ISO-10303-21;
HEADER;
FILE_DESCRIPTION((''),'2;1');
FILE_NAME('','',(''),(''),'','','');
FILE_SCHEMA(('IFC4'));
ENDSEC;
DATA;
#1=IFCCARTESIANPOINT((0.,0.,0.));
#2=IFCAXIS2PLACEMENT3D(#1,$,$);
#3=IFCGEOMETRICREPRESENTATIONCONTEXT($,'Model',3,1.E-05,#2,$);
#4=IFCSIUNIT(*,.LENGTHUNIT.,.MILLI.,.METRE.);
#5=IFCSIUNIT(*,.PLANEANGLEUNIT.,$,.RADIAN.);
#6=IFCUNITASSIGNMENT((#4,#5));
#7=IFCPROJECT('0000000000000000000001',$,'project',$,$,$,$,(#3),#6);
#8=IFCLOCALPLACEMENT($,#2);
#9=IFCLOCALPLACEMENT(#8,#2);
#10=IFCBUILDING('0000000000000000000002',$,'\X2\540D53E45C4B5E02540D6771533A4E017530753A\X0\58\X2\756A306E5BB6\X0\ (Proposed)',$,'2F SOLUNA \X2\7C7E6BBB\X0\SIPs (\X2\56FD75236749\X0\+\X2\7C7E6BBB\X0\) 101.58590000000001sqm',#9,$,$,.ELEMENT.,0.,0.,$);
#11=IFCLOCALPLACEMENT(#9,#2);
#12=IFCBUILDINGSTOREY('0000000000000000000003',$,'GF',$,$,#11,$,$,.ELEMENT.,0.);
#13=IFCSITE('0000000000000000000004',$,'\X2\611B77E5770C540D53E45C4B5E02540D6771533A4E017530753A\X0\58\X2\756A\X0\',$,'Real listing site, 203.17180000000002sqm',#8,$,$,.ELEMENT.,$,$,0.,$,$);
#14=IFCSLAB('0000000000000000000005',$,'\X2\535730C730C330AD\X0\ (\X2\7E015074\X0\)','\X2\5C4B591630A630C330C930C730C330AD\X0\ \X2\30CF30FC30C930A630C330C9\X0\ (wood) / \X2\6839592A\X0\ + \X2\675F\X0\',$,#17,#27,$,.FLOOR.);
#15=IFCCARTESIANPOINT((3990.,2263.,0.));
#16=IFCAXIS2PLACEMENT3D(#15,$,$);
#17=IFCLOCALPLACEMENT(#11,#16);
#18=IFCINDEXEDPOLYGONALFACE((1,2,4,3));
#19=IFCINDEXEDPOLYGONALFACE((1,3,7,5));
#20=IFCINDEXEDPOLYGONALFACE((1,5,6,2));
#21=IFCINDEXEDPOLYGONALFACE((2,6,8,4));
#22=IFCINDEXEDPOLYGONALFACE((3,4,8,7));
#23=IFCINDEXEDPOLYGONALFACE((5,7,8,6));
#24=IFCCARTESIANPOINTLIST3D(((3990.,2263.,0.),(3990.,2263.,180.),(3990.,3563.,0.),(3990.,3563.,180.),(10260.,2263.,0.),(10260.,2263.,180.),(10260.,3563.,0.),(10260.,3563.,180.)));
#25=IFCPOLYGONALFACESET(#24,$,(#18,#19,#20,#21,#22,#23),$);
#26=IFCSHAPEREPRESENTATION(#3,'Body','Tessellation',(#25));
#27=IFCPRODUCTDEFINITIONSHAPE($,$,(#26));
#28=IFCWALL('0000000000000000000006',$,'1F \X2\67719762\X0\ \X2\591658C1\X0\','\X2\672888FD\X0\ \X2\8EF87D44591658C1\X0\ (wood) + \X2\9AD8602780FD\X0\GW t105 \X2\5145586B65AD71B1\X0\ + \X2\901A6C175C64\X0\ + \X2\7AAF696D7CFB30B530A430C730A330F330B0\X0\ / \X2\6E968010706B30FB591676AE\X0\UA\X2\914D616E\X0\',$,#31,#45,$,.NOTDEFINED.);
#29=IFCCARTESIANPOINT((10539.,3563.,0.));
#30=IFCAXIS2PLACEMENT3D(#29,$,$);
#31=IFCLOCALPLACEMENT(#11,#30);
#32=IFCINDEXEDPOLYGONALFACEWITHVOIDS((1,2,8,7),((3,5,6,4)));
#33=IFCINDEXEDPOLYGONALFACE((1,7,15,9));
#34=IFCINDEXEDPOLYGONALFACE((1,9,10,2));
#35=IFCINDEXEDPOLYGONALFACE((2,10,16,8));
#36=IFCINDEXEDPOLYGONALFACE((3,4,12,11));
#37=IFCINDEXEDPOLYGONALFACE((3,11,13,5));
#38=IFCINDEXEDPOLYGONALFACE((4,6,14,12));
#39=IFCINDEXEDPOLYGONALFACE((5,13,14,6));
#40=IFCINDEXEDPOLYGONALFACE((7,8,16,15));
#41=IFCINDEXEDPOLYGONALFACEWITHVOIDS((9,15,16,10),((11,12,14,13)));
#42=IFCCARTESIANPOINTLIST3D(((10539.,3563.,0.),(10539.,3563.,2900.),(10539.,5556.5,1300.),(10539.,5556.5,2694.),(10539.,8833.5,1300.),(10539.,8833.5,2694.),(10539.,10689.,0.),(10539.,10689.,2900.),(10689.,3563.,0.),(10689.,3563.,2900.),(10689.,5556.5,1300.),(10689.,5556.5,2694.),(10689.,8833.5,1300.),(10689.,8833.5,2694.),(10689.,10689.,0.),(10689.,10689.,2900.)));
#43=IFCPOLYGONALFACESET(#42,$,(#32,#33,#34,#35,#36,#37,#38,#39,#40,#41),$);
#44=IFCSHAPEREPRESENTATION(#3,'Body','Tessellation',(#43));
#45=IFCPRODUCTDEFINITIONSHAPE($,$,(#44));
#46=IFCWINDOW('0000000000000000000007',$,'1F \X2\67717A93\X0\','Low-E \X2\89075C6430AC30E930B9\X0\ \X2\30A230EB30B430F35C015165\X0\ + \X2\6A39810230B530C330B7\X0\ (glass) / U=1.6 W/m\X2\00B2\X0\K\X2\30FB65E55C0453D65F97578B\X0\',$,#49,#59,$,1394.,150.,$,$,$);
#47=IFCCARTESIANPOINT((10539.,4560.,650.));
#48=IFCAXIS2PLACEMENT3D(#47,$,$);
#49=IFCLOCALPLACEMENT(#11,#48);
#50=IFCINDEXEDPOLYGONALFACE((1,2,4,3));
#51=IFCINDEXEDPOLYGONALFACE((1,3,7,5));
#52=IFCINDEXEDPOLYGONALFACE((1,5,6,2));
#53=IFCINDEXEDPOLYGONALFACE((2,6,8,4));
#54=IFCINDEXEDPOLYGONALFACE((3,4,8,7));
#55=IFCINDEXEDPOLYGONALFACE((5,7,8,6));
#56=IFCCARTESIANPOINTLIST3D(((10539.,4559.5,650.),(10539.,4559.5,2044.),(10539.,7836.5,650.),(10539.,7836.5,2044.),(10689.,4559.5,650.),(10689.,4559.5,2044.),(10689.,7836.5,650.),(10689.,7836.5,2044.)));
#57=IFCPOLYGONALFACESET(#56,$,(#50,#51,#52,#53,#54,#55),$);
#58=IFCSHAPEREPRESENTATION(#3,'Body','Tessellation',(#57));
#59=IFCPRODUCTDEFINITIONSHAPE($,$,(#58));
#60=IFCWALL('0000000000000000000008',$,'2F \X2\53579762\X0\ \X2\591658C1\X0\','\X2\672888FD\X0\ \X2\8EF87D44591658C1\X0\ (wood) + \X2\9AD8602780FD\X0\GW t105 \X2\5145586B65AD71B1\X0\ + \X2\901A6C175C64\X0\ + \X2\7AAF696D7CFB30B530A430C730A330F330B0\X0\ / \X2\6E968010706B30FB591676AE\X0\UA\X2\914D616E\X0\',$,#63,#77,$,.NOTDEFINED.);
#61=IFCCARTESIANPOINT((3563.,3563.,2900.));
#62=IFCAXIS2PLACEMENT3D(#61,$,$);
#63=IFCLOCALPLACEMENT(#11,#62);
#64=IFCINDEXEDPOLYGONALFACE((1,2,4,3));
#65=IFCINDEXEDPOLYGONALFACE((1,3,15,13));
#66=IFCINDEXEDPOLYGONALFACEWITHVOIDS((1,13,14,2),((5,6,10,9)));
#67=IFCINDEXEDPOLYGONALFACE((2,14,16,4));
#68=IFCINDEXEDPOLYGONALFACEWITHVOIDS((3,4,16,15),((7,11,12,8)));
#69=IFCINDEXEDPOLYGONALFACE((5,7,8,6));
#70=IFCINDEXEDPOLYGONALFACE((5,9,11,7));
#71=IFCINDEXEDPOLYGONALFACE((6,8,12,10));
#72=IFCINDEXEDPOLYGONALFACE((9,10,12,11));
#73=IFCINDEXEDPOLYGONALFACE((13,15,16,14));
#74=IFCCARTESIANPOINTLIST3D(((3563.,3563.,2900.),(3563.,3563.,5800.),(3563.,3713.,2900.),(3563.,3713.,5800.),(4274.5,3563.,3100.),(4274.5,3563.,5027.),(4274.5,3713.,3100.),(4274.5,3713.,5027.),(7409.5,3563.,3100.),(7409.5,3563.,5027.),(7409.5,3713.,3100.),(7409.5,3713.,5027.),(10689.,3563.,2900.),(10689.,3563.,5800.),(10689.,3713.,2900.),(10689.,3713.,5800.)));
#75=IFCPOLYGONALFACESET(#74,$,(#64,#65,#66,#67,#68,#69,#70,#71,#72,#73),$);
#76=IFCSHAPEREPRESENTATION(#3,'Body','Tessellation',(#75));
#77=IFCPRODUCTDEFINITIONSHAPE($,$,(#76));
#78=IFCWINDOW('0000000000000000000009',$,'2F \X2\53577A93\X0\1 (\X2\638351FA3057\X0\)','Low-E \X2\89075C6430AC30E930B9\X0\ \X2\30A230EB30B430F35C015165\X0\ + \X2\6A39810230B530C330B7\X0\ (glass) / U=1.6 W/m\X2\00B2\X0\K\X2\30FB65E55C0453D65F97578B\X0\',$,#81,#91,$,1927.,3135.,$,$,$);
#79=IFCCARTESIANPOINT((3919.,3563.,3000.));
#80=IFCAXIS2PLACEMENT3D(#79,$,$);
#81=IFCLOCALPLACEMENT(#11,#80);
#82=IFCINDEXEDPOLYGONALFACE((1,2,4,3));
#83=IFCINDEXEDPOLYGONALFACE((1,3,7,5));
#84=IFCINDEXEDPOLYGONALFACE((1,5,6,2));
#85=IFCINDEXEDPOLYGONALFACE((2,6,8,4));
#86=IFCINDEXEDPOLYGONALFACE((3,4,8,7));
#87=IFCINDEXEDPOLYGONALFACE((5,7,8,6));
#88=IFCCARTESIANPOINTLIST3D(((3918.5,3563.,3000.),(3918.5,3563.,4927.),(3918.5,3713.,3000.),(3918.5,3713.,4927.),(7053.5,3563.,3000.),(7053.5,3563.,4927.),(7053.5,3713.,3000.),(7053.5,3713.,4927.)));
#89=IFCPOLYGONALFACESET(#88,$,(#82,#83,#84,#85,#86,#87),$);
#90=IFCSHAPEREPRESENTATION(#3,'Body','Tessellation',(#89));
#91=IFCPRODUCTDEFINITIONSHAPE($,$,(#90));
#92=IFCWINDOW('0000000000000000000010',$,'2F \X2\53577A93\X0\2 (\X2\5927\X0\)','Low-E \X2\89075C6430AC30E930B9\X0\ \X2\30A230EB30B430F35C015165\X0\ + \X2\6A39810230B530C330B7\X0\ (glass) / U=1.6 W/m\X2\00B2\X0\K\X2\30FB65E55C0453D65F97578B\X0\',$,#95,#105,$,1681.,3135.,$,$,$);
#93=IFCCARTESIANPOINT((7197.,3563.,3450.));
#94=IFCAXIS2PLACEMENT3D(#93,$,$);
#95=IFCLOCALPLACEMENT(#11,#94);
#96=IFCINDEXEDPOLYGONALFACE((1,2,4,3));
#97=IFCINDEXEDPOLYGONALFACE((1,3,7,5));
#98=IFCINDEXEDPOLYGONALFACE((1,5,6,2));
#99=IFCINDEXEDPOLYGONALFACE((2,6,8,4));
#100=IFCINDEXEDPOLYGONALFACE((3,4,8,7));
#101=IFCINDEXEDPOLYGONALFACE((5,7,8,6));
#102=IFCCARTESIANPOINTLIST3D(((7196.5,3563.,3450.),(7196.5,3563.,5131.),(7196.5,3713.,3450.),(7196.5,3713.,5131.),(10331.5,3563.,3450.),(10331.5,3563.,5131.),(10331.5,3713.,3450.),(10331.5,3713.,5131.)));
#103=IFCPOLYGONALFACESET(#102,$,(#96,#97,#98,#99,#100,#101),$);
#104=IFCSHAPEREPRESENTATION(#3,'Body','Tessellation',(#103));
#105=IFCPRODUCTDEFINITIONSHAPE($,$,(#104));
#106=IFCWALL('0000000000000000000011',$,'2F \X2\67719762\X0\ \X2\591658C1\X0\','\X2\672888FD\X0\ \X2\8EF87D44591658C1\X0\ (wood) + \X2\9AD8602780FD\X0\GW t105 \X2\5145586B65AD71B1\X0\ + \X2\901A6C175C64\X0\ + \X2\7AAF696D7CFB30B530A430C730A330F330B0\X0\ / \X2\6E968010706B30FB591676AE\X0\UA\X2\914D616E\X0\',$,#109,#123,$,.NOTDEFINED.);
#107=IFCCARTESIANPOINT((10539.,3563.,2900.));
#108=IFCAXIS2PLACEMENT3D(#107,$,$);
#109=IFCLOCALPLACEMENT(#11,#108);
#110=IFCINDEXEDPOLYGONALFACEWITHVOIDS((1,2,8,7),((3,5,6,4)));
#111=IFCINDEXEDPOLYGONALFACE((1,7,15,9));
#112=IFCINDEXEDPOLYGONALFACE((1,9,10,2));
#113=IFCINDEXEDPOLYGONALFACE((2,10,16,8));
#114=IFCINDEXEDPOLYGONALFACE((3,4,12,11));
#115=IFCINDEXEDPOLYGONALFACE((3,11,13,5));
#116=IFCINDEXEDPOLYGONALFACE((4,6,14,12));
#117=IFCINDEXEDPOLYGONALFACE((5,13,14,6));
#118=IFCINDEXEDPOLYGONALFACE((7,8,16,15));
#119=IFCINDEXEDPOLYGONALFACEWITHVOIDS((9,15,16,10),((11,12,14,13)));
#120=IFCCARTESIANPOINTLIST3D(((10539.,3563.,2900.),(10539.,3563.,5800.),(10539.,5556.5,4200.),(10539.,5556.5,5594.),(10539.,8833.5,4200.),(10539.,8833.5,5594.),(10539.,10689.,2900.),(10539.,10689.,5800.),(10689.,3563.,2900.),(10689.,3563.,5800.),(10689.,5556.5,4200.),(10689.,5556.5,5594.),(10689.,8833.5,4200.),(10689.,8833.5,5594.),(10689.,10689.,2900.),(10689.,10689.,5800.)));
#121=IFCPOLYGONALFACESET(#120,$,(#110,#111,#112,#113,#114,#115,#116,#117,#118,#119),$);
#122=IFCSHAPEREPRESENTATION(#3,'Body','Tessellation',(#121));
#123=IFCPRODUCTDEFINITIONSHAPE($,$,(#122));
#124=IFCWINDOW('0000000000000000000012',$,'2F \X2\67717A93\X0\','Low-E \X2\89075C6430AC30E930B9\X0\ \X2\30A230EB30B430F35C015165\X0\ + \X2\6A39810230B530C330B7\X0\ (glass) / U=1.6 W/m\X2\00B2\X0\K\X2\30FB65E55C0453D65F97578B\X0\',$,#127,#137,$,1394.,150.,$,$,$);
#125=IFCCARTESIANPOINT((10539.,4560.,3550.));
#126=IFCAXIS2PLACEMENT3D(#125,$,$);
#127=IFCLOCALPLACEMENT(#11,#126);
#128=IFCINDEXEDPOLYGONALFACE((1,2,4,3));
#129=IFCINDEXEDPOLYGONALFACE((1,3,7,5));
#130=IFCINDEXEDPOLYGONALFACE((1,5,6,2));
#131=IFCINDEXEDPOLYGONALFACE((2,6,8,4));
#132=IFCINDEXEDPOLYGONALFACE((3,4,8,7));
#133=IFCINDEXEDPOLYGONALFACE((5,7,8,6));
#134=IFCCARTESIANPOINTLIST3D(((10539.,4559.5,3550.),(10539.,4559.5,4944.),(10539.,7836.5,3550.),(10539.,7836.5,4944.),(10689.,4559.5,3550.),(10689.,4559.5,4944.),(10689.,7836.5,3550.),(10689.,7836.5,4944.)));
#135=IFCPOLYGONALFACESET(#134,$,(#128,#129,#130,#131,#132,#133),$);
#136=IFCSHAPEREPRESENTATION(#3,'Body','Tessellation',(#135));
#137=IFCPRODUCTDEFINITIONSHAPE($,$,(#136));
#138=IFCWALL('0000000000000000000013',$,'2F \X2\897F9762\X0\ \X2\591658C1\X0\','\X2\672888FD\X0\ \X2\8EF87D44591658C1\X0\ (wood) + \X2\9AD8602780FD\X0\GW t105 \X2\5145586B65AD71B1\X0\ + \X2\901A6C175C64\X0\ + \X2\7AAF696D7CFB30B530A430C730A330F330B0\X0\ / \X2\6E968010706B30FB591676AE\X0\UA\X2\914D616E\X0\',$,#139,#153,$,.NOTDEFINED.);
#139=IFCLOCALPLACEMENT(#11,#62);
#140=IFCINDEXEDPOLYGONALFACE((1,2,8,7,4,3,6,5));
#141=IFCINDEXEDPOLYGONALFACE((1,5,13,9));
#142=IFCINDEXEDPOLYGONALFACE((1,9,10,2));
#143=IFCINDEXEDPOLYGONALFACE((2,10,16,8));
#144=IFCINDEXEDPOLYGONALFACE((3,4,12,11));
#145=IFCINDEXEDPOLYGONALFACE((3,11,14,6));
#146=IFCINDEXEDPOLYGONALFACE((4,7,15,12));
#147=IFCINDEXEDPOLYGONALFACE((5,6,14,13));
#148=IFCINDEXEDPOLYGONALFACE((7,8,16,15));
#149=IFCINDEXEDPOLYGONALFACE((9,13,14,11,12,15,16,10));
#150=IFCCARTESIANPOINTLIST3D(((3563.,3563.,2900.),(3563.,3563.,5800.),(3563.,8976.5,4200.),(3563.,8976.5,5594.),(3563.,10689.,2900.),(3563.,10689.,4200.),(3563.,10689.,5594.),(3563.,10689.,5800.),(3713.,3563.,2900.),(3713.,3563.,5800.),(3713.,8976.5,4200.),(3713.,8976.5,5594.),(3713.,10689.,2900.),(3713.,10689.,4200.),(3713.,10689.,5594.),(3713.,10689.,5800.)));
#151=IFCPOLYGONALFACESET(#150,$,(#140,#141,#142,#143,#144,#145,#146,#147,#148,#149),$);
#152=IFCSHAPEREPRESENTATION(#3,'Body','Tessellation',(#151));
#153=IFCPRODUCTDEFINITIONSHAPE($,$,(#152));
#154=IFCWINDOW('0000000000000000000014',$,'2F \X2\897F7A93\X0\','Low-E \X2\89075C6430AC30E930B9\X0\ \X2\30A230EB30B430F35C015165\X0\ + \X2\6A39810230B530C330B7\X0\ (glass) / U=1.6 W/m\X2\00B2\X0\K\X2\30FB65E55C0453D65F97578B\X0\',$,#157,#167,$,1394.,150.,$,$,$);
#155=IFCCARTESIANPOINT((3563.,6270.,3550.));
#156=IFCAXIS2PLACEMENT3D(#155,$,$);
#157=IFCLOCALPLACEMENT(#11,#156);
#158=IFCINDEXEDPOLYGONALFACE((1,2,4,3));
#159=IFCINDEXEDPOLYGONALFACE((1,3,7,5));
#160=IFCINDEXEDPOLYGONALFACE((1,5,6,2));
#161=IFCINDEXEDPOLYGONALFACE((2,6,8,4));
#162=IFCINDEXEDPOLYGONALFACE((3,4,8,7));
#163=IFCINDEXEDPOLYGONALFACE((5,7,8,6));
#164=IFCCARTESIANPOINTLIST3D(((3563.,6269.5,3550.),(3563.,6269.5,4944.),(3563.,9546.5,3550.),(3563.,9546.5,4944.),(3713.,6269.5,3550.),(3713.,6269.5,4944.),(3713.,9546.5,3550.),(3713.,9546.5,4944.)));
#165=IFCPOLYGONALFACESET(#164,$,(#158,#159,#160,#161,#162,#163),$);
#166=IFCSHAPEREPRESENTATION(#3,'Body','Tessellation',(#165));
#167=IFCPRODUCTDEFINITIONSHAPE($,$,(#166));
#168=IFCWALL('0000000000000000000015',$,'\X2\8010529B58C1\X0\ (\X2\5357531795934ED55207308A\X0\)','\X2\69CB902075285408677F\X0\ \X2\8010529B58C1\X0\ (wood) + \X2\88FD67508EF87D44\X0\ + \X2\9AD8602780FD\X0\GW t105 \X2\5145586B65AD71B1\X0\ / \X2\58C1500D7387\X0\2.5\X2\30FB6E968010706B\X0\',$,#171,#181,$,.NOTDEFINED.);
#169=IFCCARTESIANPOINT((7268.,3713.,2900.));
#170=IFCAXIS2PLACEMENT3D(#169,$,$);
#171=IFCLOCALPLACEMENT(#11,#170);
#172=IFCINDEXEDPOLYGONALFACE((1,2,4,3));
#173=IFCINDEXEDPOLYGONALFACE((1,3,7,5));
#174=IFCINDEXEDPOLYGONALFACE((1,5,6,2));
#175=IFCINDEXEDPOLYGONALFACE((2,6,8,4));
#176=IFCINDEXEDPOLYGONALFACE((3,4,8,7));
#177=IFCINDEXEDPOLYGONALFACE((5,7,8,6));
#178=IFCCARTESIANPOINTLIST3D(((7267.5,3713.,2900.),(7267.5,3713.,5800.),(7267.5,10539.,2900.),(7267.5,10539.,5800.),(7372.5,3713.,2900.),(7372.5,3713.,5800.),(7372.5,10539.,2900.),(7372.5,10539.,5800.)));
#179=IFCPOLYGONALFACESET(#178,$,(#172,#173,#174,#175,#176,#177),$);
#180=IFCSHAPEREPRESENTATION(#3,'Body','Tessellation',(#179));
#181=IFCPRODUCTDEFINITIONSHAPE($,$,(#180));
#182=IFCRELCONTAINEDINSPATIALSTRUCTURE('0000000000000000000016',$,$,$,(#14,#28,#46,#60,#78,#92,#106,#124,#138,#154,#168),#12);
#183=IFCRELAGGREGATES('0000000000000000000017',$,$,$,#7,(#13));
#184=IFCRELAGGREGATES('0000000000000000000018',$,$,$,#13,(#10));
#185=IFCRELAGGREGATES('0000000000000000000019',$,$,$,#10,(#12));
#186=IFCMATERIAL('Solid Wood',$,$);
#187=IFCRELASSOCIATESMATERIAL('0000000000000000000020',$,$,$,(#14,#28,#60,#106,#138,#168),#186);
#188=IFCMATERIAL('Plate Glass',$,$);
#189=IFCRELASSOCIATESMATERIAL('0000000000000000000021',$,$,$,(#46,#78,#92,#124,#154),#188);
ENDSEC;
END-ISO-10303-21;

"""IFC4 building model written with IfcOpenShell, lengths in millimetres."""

from ifc_helpers import new_model, si_unit, frame, frame_2d, origin, place, context, project, spatial, rectangle, extrude, material, element, fill, save


model = new_model("IFC4")

# Units and contexts
model_context = context("Model", 3, precision=1e-05, world=origin())
ifc_project = project(units=[si_unit("LENGTHUNIT", "METRE", prefix="MILLI"), si_unit("PLANEANGLEUNIT", "RADIAN")], contexts=[model_context])

# Site, building, storey
site_placement = place(None, origin())
site = spatial("IfcSite", under=ifc_project, at=site_placement, Name="愛知県名古屋市名東区丁田町58番", ObjectType="Real listing site, 203.17180000000002sqm", CompositionType="ELEMENT", RefElevation=0.0)
building_placement = place(site_placement, origin())
building = spatial("IfcBuilding", under=site, at=building_placement, Name="名古屋市名東区丁田町58番の家 (Proposed)", ObjectType="2F SOLUNA 籾殻SIPs (国産杉+籾殻) 101.58590000000001sqm", CompositionType="ELEMENT", ElevationOfRefHeight=0.0, ElevationOfTerrain=0.0)
storey_placement = place(building_placement, origin())
storey = spatial("IfcBuildingStorey", under=building, at=storey_placement, Name="GF", CompositionType="ELEMENT", Elevation=0.0)

# Slab
ifc_material_1 = material(Name="Solid Wood")
slab_1_placement = place(storey_placement, frame((3990.0, 2263.0, 0.0)))
element("IfcSlab", 1, at=slab_1_placement, inside=storey, material=ifc_material_1, Name="南デッキ (縁側)", Description="屋外ウッドデッキ ハードウッド (wood) / 根太 + 束", PredefinedType="FLOOR", context=model_context, shape_type="SweptSolid", body=[
    extrude(rectangle(XDim=6270.0, YDim=1300.0, at=frame_2d((3135.0, 650.0))), frame((3990.0, 2263.0, 0.0)), (0.0, 0.0, 1.0), 180.0),
])

# Shared definitions
ifc_material_2 = material(Name="Plate Glass")

# Wall, opening, window
wall_1_placement = place(storey_placement, frame((10539.0, 3563.0, 0.0)))
wall_1 = element("IfcWall", 2, at=wall_1_placement, inside=storey, material=ifc_material_1, Name="1F 東面 外壁", Description="木製 軸組外壁 (wood) + 高性能GW t105 充填断熱 + 通気層 + 窯業系サイディング / 準耐火・外皮UA配慮", PredefinedType="NOTDEFINED", context=model_context, shape_type="SweptSolid", body=[
    extrude(rectangle(XDim=150.0, YDim=7126.0, at=frame_2d((75.0, 3563.0))), frame((10539.0, 3563.0, 0.0)), (0.0, 0.0, 1.0), 2900.0),
])
opening_1_placement = place(storey_placement, frame((10539.0, 4560.0, 650.0)))
opening_1 = element("IfcOpeningElement", 3, at=opening_1_placement, cuts=wall_1, PredefinedType="NOTDEFINED", context=model_context, shape_type="SweptSolid", body=[
    extrude(rectangle(XDim=150.0, YDim=3277.0, at=frame_2d((75.0, 1638.0))), frame((10539.0, 4560.0, 650.0)), (0.0, 0.0, 1.0), 1394.0),
])
window_1_placement = place(storey_placement, frame((10539.0, 4560.0, 650.0)))
window_1 = element("IfcWindow", 4, at=window_1_placement, inside=storey, material=ifc_material_2, Name="1F 東窓", Description="Low-E 複層ガラス アルゴン封入 + 樹脂サッシ (glass) / U=1.6 W/m²K・日射取得型", OverallHeight=1394.0, OverallWidth=150.0, context=model_context, shape_type="SweptSolid", body=[
    extrude(rectangle(XDim=150.0, YDim=3277.0, at=frame_2d((75.0, 1638.0))), frame((10539.0, 4560.0, 650.0)), (0.0, 0.0, 1.0), 1394.0),
])
fill(opening_1, window_1)

# Wall, openings, windows
wall_2_placement = place(storey_placement, frame((3563.0, 3563.0, 2900.0)))
wall_2 = element("IfcWall", 5, at=wall_2_placement, inside=storey, material=ifc_material_1, Name="2F 南面 外壁", Description="木製 軸組外壁 (wood) + 高性能GW t105 充填断熱 + 通気層 + 窯業系サイディング / 準耐火・外皮UA配慮", PredefinedType="NOTDEFINED", context=model_context, shape_type="SweptSolid", body=[
    extrude(rectangle(XDim=7126.0, YDim=150.0, at=frame_2d((3563.0, 75.0))), frame((3563.0, 3563.0, 2900.0)), (0.0, 0.0, 1.0), 2900.0),
])
opening_2_placement = place(storey_placement, frame((3919.0, 3563.0, 3000.0)))
opening_2 = element("IfcOpeningElement", 6, at=opening_2_placement, cuts=wall_2, PredefinedType="NOTDEFINED", context=model_context, shape_type="SweptSolid", body=[
    extrude(rectangle(XDim=3135.0, YDim=150.0, at=frame_2d((1567.0, 75.0))), frame((3919.0, 3563.0, 3000.0)), (0.0, 0.0, 1.0), 1927.0),
])
opening_3_placement = place(storey_placement, frame((7197.0, 3563.0, 3450.0)))
opening_3 = element("IfcOpeningElement", 7, at=opening_3_placement, cuts=wall_2, PredefinedType="NOTDEFINED", context=model_context, shape_type="SweptSolid", body=[
    extrude(rectangle(XDim=3135.0, YDim=150.0, at=frame_2d((1567.0, 75.0))), frame((7197.0, 3563.0, 3450.0)), (0.0, 0.0, 1.0), 1681.0),
])
window_2_placement = place(storey_placement, frame((3919.0, 3563.0, 3000.0)))
window_2 = element("IfcWindow", 8, at=window_2_placement, inside=storey, material=ifc_material_2, Name="2F 南窓1 (掃出し)", Description="Low-E 複層ガラス アルゴン封入 + 樹脂サッシ (glass) / U=1.6 W/m²K・日射取得型", OverallHeight=1927.0, OverallWidth=3135.0, context=model_context, shape_type="SweptSolid", body=[
    extrude(rectangle(XDim=3135.0, YDim=150.0, at=frame_2d((1567.0, 75.0))), frame((3919.0, 3563.0, 3000.0)), (0.0, 0.0, 1.0), 1927.0),
])
fill(opening_2, window_2)
window_3_placement = place(storey_placement, frame((7197.0, 3563.0, 3450.0)))
window_3 = element("IfcWindow", 9, at=window_3_placement, inside=storey, material=ifc_material_2, Name="2F 南窓2 (大)", Description="Low-E 複層ガラス アルゴン封入 + 樹脂サッシ (glass) / U=1.6 W/m²K・日射取得型", OverallHeight=1681.0, OverallWidth=3135.0, context=model_context, shape_type="SweptSolid", body=[
    extrude(rectangle(XDim=3135.0, YDim=150.0, at=frame_2d((1567.0, 75.0))), frame((7197.0, 3563.0, 3450.0)), (0.0, 0.0, 1.0), 1681.0),
])
fill(opening_3, window_3)

# Walls, openings, windows
wall_3_placement = place(storey_placement, frame((10539.0, 3563.0, 2900.0)))
wall_3 = element("IfcWall", 10, at=wall_3_placement, inside=storey, material=ifc_material_1, Name="2F 東面 外壁", Description="木製 軸組外壁 (wood) + 高性能GW t105 充填断熱 + 通気層 + 窯業系サイディング / 準耐火・外皮UA配慮", PredefinedType="NOTDEFINED", context=model_context, shape_type="SweptSolid", body=[
    extrude(rectangle(XDim=150.0, YDim=7126.0, at=frame_2d((75.0, 3563.0))), frame((10539.0, 3563.0, 2900.0)), (0.0, 0.0, 1.0), 2900.0),
])
opening_4_placement = place(storey_placement, frame((10539.0, 4560.0, 3550.0)))
opening_4 = element("IfcOpeningElement", 11, at=opening_4_placement, cuts=wall_3, PredefinedType="NOTDEFINED", context=model_context, shape_type="SweptSolid", body=[
    extrude(rectangle(XDim=150.0, YDim=3277.0, at=frame_2d((75.0, 1638.0))), frame((10539.0, 4560.0, 3550.0)), (0.0, 0.0, 1.0), 1394.0),
])
window_4_placement = place(storey_placement, frame((10539.0, 4560.0, 3550.0)))
window_4 = element("IfcWindow", 12, at=window_4_placement, inside=storey, material=ifc_material_2, Name="2F 東窓", Description="Low-E 複層ガラス アルゴン封入 + 樹脂サッシ (glass) / U=1.6 W/m²K・日射取得型", OverallHeight=1394.0, OverallWidth=150.0, context=model_context, shape_type="SweptSolid", body=[
    extrude(rectangle(XDim=150.0, YDim=3277.0, at=frame_2d((75.0, 1638.0))), frame((10539.0, 4560.0, 3550.0)), (0.0, 0.0, 1.0), 1394.0),
])
fill(opening_4, window_4)
wall_4_placement = place(storey_placement, frame((3563.0, 3563.0, 2900.0)))
wall_4 = element("IfcWall", 13, at=wall_4_placement, inside=storey, material=ifc_material_1, Name="2F 西面 外壁", Description="木製 軸組外壁 (wood) + 高性能GW t105 充填断熱 + 通気層 + 窯業系サイディング / 準耐火・外皮UA配慮", PredefinedType="NOTDEFINED", context=model_context, shape_type="SweptSolid", body=[
    extrude(rectangle(XDim=150.0, YDim=7126.0, at=frame_2d((75.0, 3563.0))), frame((3563.0, 3563.0, 2900.0)), (0.0, 0.0, 1.0), 2900.0),
])
opening_5_placement = place(storey_placement, frame((3563.0, 6270.0, 3550.0)))
opening_5 = element("IfcOpeningElement", 14, at=opening_5_placement, cuts=wall_4, PredefinedType="NOTDEFINED", context=model_context, shape_type="SweptSolid", body=[
    extrude(rectangle(XDim=150.0, YDim=3277.0, at=frame_2d((75.0, 1638.0))), frame((3563.0, 6270.0, 3550.0)), (0.0, 0.0, 1.0), 1394.0),
])
window_5_placement = place(storey_placement, frame((3563.0, 6270.0, 3550.0)))
window_5 = element("IfcWindow", 15, at=window_5_placement, inside=storey, material=ifc_material_2, Name="2F 西窓", Description="Low-E 複層ガラス アルゴン封入 + 樹脂サッシ (glass) / U=1.6 W/m²K・日射取得型", OverallHeight=1394.0, OverallWidth=150.0, context=model_context, shape_type="SweptSolid", body=[
    extrude(rectangle(XDim=150.0, YDim=3277.0, at=frame_2d((75.0, 1638.0))), frame((3563.0, 6270.0, 3550.0)), (0.0, 0.0, 1.0), 1394.0),
])
fill(opening_5, window_5)

# Wall
wall_5_placement = place(storey_placement, frame((7268.0, 3713.0, 2900.0)))
element("IfcWall", 16, at=wall_5_placement, inside=storey, material=ifc_material_1, Name="耐力壁 (南北間仕切り)", Description="構造用合板 耐力壁 (wood) + 製材軸組 + 高性能GW t105 充填断熱 / 壁倍率2.5・準耐火", PredefinedType="NOTDEFINED", context=model_context, shape_type="SweptSolid", body=[
    extrude(rectangle(XDim=105.0, YDim=6826.0, at=frame_2d((52.0, 3413.0))), frame((7268.0, 3713.0, 2900.0)), (0.0, 0.0, 1.0), 2900.0),
])

save(model, "model.ifc")
